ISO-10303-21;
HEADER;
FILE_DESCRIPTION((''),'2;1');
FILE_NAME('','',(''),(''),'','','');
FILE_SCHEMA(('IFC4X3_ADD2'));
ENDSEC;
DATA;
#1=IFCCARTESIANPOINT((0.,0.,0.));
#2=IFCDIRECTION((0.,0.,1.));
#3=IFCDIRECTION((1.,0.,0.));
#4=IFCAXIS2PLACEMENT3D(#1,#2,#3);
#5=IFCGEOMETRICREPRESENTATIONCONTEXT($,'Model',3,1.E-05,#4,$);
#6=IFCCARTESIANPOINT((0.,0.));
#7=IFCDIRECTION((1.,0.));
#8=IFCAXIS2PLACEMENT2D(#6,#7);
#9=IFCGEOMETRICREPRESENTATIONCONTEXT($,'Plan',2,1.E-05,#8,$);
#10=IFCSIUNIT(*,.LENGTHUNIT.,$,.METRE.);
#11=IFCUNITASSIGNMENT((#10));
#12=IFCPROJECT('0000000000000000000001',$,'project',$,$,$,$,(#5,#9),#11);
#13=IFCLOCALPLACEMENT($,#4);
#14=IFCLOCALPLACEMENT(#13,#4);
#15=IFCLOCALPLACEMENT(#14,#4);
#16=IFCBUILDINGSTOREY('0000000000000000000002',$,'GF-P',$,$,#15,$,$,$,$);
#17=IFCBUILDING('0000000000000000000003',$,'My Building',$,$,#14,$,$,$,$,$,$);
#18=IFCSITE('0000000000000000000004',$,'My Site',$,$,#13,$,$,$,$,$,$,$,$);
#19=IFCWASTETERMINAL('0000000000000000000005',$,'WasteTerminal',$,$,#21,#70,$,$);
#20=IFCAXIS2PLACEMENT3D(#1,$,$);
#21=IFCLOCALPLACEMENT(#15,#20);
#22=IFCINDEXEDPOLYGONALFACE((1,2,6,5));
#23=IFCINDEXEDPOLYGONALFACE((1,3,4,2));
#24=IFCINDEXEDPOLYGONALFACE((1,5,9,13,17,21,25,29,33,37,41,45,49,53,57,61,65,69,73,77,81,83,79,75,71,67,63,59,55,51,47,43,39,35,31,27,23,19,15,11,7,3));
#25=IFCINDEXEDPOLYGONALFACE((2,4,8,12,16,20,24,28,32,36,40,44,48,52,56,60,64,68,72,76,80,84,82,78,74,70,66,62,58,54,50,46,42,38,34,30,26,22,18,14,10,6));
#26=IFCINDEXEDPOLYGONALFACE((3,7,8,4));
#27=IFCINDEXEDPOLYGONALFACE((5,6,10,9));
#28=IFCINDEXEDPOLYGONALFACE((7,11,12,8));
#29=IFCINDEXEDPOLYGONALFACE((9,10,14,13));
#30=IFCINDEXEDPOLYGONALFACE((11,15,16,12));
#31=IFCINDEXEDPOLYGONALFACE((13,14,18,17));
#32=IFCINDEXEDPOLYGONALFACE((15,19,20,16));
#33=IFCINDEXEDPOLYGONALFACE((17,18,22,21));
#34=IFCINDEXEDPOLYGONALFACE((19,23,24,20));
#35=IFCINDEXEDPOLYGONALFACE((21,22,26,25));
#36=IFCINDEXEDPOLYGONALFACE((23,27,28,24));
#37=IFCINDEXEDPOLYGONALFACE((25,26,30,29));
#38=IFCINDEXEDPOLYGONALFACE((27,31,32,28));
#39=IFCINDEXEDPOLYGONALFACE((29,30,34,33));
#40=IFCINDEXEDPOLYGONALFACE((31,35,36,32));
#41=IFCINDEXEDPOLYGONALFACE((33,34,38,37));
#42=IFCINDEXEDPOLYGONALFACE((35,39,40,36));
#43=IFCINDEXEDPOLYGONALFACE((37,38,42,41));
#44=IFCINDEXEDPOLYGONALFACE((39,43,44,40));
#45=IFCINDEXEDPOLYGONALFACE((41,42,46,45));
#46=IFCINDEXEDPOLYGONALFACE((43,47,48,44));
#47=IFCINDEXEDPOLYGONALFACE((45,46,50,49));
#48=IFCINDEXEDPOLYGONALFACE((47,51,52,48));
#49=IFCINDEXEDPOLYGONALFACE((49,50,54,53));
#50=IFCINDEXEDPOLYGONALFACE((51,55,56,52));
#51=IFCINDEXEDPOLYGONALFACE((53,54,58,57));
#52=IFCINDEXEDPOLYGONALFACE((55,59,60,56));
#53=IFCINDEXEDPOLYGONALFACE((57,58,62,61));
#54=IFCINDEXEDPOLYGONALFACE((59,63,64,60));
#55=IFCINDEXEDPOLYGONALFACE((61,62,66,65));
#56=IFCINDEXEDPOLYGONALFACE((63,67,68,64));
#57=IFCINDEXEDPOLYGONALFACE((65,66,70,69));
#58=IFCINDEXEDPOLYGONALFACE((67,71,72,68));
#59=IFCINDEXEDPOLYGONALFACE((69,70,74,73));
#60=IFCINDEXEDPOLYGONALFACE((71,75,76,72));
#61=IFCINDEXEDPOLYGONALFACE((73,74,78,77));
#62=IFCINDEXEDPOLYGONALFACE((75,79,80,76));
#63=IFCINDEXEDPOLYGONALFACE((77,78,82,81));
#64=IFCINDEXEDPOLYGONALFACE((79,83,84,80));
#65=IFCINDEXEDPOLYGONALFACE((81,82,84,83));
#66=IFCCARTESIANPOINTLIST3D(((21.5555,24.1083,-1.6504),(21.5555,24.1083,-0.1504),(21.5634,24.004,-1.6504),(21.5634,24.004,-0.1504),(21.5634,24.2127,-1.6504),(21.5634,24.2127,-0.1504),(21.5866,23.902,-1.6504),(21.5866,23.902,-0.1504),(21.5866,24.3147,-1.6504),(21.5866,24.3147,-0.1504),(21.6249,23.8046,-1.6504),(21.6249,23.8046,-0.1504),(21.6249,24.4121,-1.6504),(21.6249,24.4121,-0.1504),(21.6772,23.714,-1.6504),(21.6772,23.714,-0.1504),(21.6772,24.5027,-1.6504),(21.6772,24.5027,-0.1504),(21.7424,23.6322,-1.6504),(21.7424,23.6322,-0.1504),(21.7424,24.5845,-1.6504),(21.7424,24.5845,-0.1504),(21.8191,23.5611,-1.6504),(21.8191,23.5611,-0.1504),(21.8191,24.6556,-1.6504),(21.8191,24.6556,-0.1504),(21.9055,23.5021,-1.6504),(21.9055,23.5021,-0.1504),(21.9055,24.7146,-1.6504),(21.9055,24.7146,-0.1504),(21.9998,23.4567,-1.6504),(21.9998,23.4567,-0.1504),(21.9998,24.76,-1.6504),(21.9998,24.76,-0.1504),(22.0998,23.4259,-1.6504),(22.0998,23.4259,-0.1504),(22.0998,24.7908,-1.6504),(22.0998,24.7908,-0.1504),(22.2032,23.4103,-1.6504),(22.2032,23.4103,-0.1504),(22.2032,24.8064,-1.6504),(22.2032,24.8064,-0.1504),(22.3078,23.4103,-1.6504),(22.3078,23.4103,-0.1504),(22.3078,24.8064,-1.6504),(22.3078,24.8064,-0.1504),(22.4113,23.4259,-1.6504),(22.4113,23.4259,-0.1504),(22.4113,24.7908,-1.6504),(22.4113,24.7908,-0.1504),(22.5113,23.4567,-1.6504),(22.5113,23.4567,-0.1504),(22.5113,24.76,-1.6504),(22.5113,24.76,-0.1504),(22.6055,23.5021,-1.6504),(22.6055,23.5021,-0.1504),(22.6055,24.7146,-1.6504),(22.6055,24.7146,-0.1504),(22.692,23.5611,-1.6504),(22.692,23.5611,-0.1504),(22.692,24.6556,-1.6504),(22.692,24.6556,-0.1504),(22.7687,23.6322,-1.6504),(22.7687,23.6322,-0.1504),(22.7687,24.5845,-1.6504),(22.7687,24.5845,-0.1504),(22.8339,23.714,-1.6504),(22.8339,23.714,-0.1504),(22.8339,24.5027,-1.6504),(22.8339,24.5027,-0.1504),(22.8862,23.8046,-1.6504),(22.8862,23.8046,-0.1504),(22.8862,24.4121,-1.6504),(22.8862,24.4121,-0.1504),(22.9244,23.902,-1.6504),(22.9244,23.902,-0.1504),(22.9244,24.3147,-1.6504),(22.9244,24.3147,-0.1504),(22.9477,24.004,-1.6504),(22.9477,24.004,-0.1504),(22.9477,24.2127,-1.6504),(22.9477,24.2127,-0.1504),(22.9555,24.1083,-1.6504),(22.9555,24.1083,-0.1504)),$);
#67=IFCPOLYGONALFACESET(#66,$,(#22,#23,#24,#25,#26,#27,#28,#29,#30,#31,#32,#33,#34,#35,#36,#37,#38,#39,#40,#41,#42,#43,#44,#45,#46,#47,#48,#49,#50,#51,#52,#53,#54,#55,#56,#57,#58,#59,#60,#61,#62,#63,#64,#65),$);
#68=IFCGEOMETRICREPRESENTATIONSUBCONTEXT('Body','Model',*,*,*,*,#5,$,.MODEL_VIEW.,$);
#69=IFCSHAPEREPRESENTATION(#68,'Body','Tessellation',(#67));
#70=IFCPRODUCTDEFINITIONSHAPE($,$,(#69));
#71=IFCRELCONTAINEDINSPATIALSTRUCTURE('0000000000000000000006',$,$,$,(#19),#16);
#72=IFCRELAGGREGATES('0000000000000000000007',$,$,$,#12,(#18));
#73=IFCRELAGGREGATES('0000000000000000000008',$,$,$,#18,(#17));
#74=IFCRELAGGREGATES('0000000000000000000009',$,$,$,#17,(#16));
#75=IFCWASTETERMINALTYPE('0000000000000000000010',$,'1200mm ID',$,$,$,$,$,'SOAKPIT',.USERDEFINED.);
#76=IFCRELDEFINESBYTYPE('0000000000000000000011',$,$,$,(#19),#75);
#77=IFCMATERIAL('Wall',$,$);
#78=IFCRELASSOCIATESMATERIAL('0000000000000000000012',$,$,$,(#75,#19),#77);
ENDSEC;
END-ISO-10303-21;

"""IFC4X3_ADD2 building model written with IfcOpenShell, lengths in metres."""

from ifc_helpers import new_model, si_unit, frame, origin_with_axes, origin_2d_with_axis, place, context, subcontext, project, spatial, circle, extrude, material, material_profile, profile_set, profile_usage, type_object, element, save


model = new_model("IFC4X3_ADD2")

# Units and contexts
model_context = context("Model", 3, precision=1e-05, world=origin_with_axes())
plan_context = context("Plan", 2, precision=1e-05, world=origin_2d_with_axis())
body_context = subcontext(model_context, "Body", "Model", "MODEL_VIEW")
ifc_project = project(units=[si_unit("LENGTHUNIT", "METRE")], contexts=[model_context, plan_context])

# Site, building, storey
site_placement = place(None, origin_with_axes())
site = spatial("IfcSite", under=ifc_project, at=site_placement, Name="My Site")
building_placement = place(site_placement, origin_with_axes())
building = spatial("IfcBuilding", under=site, at=building_placement, Name="My Building")
storey_placement = place(building_placement, origin_with_axes())
storey = spatial("IfcBuildingStorey", under=building, at=storey_placement, Name="GF-P")

# Shared definitions
ifc_material_1 = material(Name="Wall")

# Waste terminal
ifc_material_profile_1 = material_profile(ifc_material_1, circle(Radius=0.7))
ifc_profile_set_1 = profile_set([ifc_material_profile_1])
waste_terminal_type = type_object("IfcWasteTerminalType", Name="1200mm ID", ElementType="SOAKPIT", PredefinedType="USERDEFINED", material=ifc_profile_set_1)
ifc_profile_usage_1 = profile_usage(ifc_profile_set_1, cardinal=5)
waste_terminal_1_placement = place(storey_placement, frame((22.2555, 24.1083, -0.1504), z_axis=(0.0, 0.0, -1.0), x_axis=(-1.0, 0.0, 0.0)))
element("IfcWasteTerminal", 1, at=waste_terminal_1_placement, inside=storey, type_object=waste_terminal_type, material=ifc_profile_usage_1, Name="WasteTerminal", context=body_context, shape_type="SweptSolid", body=[
    extrude(circle(Radius=0.7), origin_with_axes(), (0.0, 0.0, 1.0), 1.5),
])

save(model, "model.ifc")
